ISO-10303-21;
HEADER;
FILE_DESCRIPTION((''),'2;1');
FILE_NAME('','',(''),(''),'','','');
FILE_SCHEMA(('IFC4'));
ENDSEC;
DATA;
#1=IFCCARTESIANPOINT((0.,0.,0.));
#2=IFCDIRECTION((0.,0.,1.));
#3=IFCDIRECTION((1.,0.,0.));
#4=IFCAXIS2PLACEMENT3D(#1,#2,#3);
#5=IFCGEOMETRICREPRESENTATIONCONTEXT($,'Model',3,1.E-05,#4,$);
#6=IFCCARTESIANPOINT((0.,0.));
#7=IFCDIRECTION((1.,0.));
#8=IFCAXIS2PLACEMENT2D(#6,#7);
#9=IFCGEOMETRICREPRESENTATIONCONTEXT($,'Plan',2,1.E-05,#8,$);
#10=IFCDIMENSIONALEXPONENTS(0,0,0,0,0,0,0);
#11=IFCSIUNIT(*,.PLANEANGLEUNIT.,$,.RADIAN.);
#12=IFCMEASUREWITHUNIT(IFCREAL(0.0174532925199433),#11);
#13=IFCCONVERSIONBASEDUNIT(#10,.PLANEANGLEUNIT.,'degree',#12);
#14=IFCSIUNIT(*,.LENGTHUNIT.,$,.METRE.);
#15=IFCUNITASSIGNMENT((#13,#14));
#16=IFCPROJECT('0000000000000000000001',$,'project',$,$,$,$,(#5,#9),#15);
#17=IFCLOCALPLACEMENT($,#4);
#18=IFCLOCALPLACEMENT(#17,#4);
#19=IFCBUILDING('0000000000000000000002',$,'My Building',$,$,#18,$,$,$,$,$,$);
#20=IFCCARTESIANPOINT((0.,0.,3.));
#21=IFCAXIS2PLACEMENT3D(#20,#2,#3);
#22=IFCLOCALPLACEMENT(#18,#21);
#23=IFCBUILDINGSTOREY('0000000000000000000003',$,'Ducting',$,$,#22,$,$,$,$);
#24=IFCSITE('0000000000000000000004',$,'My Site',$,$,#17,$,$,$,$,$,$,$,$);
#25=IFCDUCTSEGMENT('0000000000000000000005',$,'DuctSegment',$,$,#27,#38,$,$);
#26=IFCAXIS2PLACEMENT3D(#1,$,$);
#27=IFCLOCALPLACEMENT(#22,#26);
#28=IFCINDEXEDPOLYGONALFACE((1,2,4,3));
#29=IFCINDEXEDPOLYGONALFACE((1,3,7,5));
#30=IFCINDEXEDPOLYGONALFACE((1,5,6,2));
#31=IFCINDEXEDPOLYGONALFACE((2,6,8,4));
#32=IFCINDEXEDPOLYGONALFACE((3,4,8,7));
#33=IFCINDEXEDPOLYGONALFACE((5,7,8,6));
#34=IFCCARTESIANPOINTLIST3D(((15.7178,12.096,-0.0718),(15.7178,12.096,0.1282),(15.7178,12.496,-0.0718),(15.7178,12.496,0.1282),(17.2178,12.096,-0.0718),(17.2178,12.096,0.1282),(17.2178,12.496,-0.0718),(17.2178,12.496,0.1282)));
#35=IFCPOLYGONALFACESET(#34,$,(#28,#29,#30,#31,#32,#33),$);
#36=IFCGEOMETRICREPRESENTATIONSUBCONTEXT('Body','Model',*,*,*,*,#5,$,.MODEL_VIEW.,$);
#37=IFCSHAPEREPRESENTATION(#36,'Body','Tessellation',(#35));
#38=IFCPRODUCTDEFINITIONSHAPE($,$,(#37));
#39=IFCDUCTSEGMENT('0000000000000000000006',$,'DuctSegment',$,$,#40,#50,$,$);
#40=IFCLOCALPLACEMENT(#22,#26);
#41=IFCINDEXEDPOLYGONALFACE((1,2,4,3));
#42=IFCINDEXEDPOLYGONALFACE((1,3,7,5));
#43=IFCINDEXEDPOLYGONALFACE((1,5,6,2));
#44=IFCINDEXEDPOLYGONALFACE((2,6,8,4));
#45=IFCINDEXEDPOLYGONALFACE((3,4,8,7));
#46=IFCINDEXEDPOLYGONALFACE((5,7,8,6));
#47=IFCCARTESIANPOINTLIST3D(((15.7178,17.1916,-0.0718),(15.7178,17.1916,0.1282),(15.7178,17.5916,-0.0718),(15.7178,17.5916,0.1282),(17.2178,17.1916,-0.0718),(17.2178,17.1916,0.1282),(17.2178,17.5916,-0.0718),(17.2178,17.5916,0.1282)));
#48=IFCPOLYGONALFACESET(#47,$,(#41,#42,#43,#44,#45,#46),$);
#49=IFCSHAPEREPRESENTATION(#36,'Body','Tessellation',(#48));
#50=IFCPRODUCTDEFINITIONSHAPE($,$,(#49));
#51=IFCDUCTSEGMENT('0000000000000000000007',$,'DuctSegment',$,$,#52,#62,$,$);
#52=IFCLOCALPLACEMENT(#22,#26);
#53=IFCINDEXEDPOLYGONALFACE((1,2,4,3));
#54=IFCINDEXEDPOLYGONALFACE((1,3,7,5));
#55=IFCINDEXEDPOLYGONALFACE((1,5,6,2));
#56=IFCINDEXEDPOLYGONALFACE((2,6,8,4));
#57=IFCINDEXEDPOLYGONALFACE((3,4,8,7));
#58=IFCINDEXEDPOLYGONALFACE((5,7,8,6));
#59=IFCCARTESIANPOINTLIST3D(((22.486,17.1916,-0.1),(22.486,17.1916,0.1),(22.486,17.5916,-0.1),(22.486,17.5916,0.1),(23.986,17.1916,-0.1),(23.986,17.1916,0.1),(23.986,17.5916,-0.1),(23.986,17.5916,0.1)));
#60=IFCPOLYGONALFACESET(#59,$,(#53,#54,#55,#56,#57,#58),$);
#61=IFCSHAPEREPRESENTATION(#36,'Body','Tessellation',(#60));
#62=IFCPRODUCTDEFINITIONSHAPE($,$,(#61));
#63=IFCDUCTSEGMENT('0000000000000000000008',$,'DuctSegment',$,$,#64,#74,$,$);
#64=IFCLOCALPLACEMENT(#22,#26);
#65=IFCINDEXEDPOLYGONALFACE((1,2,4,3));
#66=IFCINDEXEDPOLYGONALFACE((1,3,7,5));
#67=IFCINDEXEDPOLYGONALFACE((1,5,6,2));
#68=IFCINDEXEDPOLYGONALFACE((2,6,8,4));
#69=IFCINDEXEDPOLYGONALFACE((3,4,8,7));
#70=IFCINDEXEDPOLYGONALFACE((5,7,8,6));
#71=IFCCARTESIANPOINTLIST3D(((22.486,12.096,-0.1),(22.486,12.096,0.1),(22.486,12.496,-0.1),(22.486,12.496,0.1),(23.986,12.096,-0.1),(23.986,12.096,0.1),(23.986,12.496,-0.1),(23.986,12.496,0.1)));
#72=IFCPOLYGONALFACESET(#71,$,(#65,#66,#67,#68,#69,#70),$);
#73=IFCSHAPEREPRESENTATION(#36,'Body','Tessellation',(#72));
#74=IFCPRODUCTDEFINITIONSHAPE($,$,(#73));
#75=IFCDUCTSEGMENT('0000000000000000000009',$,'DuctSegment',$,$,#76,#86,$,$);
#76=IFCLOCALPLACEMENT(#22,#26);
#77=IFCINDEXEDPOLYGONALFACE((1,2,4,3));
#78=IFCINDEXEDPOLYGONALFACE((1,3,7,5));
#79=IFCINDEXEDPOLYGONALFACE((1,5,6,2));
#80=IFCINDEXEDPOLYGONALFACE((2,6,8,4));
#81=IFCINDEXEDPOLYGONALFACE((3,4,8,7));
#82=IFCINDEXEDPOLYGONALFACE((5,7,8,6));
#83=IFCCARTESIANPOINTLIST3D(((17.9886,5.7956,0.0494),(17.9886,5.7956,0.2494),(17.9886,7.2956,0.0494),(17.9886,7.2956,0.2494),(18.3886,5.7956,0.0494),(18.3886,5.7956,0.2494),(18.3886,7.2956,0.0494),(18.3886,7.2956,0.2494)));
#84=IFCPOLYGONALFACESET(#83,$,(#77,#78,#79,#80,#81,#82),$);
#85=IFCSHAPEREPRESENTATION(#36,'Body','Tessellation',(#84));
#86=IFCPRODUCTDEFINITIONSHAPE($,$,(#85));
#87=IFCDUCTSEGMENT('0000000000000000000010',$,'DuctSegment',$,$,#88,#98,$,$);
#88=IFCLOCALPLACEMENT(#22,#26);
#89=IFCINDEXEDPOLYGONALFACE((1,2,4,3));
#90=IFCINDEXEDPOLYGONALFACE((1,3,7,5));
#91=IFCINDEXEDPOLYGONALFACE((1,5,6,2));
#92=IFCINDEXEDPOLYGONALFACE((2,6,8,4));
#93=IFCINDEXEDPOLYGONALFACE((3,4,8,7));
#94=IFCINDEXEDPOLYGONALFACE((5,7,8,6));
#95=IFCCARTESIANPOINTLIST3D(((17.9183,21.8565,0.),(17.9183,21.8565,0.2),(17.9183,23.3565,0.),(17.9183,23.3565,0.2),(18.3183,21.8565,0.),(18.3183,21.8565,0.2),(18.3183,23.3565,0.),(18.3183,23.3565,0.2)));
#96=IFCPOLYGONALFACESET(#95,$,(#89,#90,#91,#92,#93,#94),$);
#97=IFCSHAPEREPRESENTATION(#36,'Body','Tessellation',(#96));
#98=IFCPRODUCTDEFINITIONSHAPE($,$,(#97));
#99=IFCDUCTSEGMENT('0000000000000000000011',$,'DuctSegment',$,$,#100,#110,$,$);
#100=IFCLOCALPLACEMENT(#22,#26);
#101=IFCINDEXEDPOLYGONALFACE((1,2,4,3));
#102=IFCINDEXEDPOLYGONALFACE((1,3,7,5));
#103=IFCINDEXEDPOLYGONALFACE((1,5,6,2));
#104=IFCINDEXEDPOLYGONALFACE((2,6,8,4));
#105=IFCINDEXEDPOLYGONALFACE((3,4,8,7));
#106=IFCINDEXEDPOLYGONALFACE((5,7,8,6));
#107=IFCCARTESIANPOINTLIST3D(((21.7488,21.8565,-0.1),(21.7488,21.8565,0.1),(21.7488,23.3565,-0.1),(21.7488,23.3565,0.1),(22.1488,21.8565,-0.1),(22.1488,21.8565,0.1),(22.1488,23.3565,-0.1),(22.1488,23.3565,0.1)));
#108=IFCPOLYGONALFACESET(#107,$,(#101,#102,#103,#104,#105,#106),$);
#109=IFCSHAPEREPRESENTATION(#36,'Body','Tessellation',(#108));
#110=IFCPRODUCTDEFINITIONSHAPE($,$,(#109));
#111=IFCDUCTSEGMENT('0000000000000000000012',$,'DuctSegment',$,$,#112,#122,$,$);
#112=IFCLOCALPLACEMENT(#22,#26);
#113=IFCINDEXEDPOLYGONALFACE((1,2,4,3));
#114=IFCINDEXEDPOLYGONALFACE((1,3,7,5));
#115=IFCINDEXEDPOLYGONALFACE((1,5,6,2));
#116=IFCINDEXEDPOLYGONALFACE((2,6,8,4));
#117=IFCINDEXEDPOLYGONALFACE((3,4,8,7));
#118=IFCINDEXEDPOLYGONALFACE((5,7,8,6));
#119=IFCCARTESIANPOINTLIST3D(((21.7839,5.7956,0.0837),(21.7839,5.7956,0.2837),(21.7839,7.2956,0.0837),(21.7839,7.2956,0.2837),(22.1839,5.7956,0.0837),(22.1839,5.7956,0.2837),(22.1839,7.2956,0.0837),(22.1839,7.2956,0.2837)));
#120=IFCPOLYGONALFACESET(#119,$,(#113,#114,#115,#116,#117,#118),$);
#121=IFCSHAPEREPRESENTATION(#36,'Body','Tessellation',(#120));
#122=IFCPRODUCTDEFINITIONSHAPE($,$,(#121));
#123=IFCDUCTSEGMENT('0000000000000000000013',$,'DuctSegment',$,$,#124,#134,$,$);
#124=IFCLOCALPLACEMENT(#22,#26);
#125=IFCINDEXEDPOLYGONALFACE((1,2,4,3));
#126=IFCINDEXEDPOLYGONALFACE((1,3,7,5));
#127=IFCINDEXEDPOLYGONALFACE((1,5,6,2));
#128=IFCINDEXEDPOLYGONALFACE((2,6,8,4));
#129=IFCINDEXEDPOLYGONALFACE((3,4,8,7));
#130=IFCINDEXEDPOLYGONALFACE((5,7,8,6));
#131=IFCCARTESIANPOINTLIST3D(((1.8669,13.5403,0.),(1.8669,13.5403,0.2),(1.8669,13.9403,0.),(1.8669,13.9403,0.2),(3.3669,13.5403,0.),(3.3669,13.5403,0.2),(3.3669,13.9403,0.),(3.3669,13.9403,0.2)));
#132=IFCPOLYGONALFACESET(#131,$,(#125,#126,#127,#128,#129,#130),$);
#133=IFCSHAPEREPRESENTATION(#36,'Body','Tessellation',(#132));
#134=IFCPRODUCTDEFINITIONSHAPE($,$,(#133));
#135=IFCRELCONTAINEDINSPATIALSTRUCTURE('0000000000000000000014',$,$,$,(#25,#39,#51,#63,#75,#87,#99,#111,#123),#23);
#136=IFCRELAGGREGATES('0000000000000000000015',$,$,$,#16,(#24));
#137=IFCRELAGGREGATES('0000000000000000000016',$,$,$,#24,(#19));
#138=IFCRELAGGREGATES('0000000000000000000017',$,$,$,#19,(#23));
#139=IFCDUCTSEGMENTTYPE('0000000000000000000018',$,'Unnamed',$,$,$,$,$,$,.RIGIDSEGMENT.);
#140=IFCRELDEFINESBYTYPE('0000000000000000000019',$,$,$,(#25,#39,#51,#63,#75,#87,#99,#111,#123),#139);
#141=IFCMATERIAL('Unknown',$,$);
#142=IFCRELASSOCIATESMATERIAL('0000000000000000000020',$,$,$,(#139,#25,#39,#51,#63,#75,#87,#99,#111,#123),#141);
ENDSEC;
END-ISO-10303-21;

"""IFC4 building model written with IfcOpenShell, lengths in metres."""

from ifc_helpers import new_model, entity, si_unit, converted_unit, frame, origin_with_axes, origin_2d_with_axis, place, context, subcontext, project, spatial, rectangle, extrude, material, material_profile, profile_set, profile_usage, type_object, element, save


model = new_model("IFC4")

# Units and contexts
model_context = context("Model", 3, precision=1e-05, world=origin_with_axes())
plan_context = context("Plan", 2, precision=1e-05, world=origin_2d_with_axis())
body_context = subcontext(model_context, "Body", "Model", "MODEL_VIEW")
ifc_project = project(units=[converted_unit("PLANEANGLEUNIT", "degree", entity("IfcReal", 0.0174532925199433), si_unit("PLANEANGLEUNIT", "RADIAN"), dimensions=[0, 0, 0, 0, 0, 0, 0]), si_unit("LENGTHUNIT", "METRE")], contexts=[model_context, plan_context])

# Site, building, storey
site_placement = place(None, origin_with_axes())
site = spatial("IfcSite", under=ifc_project, at=site_placement, Name="My Site")
building_placement = place(site_placement, origin_with_axes())
building = spatial("IfcBuilding", under=site, at=building_placement, Name="My Building")
storey_placement = place(building_placement, frame((0.0, 0.0, 3.0), z_axis=(0.0, 0.0, 1.0), x_axis=(1.0, 0.0, 0.0)))
storey = spatial("IfcBuildingStorey", under=building, at=storey_placement, Name="Ducting")

# Duct segments
ifc_material = material(Name="Unknown")
ifc_material_profile = material_profile(ifc_material, rectangle(XDim=0.4, YDim=0.2))
ifc_profile_set = profile_set([ifc_material_profile])
duct_segment_type = type_object("IfcDuctSegmentType", Name="Unnamed", PredefinedType="RIGIDSEGMENT", material=ifc_profile_set)
ifc_profile_usage_1 = profile_usage(ifc_profile_set, cardinal=5)
duct_segment_1_placement = place(storey_placement, frame((15.7178, 12.296, 0.0282), z_axis=(1.0, 0.0, 0.0), x_axis=(0.0, 1.0, 0.0)))
element("IfcDuctSegment", 1, at=duct_segment_1_placement, inside=storey, type_object=duct_segment_type, material=ifc_profile_usage_1, Name="DuctSegment", context=body_context, shape_type="SweptSolid", body=[
    extrude(rectangle(XDim=0.4, YDim=0.2), origin_with_axes(), (0.0, 0.0, 1.0), 1.5),
])
ifc_profile_usage_2 = profile_usage(ifc_profile_set, cardinal=5)
duct_segment_2_placement = place(storey_placement, frame((15.7178, 17.3916, 0.0282), z_axis=(1.0, 0.0, 0.0), x_axis=(0.0, 1.0, 0.0)))
element("IfcDuctSegment", 2, at=duct_segment_2_placement, inside=storey, type_object=duct_segment_type, material=ifc_profile_usage_2, Name="DuctSegment", context=body_context, shape_type="SweptSolid", body=[
    extrude(rectangle(XDim=0.4, YDim=0.2), origin_with_axes(), (0.0, 0.0, 1.0), 1.5),
])
ifc_profile_usage_3 = profile_usage(ifc_profile_set, cardinal=5)
duct_segment_3_placement = place(storey_placement, frame((22.486, 17.3916, 0.0), z_axis=(1.0, 0.0, 0.0), x_axis=(0.0, 1.0, 0.0)))
element("IfcDuctSegment", 3, at=duct_segment_3_placement, inside=storey, type_object=duct_segment_type, material=ifc_profile_usage_3, Name="DuctSegment", context=body_context, shape_type="SweptSolid", body=[
    extrude(rectangle(XDim=0.4, YDim=0.2), origin_with_axes(), (0.0, 0.0, 1.0), 1.5),
])
ifc_profile_usage_4 = profile_usage(ifc_profile_set, cardinal=5)
duct_segment_4_placement = place(storey_placement, frame((22.486, 12.296, 0.0), z_axis=(1.0, 0.0, 0.0), x_axis=(0.0, 1.0, 0.0)))
element("IfcDuctSegment", 4, at=duct_segment_4_placement, inside=storey, type_object=duct_segment_type, material=ifc_profile_usage_4, Name="DuctSegment", context=body_context, shape_type="SweptSolid", body=[
    extrude(rectangle(XDim=0.4, YDim=0.2), origin_with_axes(), (0.0, 0.0, 1.0), 1.5),
])
ifc_profile_usage_5 = profile_usage(ifc_profile_set, cardinal=5)
duct_segment_5_placement = place(storey_placement, frame((18.1886, 5.7956, 0.1494), z_axis=(0.0, 1.0, 0.0), x_axis=(-1.0, 0.0, 0.0)))
element("IfcDuctSegment", 5, at=duct_segment_5_placement, inside=storey, type_object=duct_segment_type, material=ifc_profile_usage_5, Name="DuctSegment", context=body_context, shape_type="SweptSolid", body=[
    extrude(rectangle(XDim=0.4, YDim=0.2), origin_with_axes(), (0.0, 0.0, 1.0), 1.5),
])
ifc_profile_usage_6 = profile_usage(ifc_profile_set, cardinal=5)
duct_segment_6_placement = place(storey_placement, frame((18.1183, 23.3565, 0.1), z_axis=(0.0, -1.0, 0.0), x_axis=(1.0, 0.0, 0.0)))
element("IfcDuctSegment", 6, at=duct_segment_6_placement, inside=storey, type_object=duct_segment_type, material=ifc_profile_usage_6, Name="DuctSegment", context=body_context, shape_type="SweptSolid", body=[
    extrude(rectangle(XDim=0.4, YDim=0.2), origin_with_axes(), (0.0, 0.0, 1.0), 1.5),
])
ifc_profile_usage_7 = profile_usage(ifc_profile_set, cardinal=5)
duct_segment_7_placement = place(storey_placement, frame((21.9488, 23.3565, 0.0), z_axis=(0.0, -1.0, 0.0), x_axis=(1.0, 0.0, 0.0)))
element("IfcDuctSegment", 7, at=duct_segment_7_placement, inside=storey, type_object=duct_segment_type, material=ifc_profile_usage_7, Name="DuctSegment", context=body_context, shape_type="SweptSolid", body=[
    extrude(rectangle(XDim=0.4, YDim=0.2), origin_with_axes(), (0.0, 0.0, 1.0), 1.5),
])
ifc_profile_usage_8 = profile_usage(ifc_profile_set, cardinal=5)
duct_segment_8_placement = place(storey_placement, frame((21.9839, 5.7956, 0.1837), z_axis=(0.0, 1.0, 0.0), x_axis=(-1.0, 0.0, 0.0)))
element("IfcDuctSegment", 8, at=duct_segment_8_placement, inside=storey, type_object=duct_segment_type, material=ifc_profile_usage_8, Name="DuctSegment", context=body_context, shape_type="SweptSolid", body=[
    extrude(rectangle(XDim=0.4, YDim=0.2), origin_with_axes(), (0.0, 0.0, 1.0), 1.5),
])
ifc_profile_usage_9 = profile_usage(ifc_profile_set, cardinal=5)
duct_segment_9_placement = place(storey_placement, frame((1.8669, 13.7403, 0.1), z_axis=(1.0, 0.0, 0.0), x_axis=(0.0, 1.0, 0.0)))
element("IfcDuctSegment", 9, at=duct_segment_9_placement, inside=storey, type_object=duct_segment_type, material=ifc_profile_usage_9, Name="DuctSegment", context=body_context, shape_type="SweptSolid", body=[
    extrude(rectangle(XDim=0.4, YDim=0.2), origin_with_axes(), (0.0, 0.0, 1.0), 1.5),
])

save(model, "model.ifc")
